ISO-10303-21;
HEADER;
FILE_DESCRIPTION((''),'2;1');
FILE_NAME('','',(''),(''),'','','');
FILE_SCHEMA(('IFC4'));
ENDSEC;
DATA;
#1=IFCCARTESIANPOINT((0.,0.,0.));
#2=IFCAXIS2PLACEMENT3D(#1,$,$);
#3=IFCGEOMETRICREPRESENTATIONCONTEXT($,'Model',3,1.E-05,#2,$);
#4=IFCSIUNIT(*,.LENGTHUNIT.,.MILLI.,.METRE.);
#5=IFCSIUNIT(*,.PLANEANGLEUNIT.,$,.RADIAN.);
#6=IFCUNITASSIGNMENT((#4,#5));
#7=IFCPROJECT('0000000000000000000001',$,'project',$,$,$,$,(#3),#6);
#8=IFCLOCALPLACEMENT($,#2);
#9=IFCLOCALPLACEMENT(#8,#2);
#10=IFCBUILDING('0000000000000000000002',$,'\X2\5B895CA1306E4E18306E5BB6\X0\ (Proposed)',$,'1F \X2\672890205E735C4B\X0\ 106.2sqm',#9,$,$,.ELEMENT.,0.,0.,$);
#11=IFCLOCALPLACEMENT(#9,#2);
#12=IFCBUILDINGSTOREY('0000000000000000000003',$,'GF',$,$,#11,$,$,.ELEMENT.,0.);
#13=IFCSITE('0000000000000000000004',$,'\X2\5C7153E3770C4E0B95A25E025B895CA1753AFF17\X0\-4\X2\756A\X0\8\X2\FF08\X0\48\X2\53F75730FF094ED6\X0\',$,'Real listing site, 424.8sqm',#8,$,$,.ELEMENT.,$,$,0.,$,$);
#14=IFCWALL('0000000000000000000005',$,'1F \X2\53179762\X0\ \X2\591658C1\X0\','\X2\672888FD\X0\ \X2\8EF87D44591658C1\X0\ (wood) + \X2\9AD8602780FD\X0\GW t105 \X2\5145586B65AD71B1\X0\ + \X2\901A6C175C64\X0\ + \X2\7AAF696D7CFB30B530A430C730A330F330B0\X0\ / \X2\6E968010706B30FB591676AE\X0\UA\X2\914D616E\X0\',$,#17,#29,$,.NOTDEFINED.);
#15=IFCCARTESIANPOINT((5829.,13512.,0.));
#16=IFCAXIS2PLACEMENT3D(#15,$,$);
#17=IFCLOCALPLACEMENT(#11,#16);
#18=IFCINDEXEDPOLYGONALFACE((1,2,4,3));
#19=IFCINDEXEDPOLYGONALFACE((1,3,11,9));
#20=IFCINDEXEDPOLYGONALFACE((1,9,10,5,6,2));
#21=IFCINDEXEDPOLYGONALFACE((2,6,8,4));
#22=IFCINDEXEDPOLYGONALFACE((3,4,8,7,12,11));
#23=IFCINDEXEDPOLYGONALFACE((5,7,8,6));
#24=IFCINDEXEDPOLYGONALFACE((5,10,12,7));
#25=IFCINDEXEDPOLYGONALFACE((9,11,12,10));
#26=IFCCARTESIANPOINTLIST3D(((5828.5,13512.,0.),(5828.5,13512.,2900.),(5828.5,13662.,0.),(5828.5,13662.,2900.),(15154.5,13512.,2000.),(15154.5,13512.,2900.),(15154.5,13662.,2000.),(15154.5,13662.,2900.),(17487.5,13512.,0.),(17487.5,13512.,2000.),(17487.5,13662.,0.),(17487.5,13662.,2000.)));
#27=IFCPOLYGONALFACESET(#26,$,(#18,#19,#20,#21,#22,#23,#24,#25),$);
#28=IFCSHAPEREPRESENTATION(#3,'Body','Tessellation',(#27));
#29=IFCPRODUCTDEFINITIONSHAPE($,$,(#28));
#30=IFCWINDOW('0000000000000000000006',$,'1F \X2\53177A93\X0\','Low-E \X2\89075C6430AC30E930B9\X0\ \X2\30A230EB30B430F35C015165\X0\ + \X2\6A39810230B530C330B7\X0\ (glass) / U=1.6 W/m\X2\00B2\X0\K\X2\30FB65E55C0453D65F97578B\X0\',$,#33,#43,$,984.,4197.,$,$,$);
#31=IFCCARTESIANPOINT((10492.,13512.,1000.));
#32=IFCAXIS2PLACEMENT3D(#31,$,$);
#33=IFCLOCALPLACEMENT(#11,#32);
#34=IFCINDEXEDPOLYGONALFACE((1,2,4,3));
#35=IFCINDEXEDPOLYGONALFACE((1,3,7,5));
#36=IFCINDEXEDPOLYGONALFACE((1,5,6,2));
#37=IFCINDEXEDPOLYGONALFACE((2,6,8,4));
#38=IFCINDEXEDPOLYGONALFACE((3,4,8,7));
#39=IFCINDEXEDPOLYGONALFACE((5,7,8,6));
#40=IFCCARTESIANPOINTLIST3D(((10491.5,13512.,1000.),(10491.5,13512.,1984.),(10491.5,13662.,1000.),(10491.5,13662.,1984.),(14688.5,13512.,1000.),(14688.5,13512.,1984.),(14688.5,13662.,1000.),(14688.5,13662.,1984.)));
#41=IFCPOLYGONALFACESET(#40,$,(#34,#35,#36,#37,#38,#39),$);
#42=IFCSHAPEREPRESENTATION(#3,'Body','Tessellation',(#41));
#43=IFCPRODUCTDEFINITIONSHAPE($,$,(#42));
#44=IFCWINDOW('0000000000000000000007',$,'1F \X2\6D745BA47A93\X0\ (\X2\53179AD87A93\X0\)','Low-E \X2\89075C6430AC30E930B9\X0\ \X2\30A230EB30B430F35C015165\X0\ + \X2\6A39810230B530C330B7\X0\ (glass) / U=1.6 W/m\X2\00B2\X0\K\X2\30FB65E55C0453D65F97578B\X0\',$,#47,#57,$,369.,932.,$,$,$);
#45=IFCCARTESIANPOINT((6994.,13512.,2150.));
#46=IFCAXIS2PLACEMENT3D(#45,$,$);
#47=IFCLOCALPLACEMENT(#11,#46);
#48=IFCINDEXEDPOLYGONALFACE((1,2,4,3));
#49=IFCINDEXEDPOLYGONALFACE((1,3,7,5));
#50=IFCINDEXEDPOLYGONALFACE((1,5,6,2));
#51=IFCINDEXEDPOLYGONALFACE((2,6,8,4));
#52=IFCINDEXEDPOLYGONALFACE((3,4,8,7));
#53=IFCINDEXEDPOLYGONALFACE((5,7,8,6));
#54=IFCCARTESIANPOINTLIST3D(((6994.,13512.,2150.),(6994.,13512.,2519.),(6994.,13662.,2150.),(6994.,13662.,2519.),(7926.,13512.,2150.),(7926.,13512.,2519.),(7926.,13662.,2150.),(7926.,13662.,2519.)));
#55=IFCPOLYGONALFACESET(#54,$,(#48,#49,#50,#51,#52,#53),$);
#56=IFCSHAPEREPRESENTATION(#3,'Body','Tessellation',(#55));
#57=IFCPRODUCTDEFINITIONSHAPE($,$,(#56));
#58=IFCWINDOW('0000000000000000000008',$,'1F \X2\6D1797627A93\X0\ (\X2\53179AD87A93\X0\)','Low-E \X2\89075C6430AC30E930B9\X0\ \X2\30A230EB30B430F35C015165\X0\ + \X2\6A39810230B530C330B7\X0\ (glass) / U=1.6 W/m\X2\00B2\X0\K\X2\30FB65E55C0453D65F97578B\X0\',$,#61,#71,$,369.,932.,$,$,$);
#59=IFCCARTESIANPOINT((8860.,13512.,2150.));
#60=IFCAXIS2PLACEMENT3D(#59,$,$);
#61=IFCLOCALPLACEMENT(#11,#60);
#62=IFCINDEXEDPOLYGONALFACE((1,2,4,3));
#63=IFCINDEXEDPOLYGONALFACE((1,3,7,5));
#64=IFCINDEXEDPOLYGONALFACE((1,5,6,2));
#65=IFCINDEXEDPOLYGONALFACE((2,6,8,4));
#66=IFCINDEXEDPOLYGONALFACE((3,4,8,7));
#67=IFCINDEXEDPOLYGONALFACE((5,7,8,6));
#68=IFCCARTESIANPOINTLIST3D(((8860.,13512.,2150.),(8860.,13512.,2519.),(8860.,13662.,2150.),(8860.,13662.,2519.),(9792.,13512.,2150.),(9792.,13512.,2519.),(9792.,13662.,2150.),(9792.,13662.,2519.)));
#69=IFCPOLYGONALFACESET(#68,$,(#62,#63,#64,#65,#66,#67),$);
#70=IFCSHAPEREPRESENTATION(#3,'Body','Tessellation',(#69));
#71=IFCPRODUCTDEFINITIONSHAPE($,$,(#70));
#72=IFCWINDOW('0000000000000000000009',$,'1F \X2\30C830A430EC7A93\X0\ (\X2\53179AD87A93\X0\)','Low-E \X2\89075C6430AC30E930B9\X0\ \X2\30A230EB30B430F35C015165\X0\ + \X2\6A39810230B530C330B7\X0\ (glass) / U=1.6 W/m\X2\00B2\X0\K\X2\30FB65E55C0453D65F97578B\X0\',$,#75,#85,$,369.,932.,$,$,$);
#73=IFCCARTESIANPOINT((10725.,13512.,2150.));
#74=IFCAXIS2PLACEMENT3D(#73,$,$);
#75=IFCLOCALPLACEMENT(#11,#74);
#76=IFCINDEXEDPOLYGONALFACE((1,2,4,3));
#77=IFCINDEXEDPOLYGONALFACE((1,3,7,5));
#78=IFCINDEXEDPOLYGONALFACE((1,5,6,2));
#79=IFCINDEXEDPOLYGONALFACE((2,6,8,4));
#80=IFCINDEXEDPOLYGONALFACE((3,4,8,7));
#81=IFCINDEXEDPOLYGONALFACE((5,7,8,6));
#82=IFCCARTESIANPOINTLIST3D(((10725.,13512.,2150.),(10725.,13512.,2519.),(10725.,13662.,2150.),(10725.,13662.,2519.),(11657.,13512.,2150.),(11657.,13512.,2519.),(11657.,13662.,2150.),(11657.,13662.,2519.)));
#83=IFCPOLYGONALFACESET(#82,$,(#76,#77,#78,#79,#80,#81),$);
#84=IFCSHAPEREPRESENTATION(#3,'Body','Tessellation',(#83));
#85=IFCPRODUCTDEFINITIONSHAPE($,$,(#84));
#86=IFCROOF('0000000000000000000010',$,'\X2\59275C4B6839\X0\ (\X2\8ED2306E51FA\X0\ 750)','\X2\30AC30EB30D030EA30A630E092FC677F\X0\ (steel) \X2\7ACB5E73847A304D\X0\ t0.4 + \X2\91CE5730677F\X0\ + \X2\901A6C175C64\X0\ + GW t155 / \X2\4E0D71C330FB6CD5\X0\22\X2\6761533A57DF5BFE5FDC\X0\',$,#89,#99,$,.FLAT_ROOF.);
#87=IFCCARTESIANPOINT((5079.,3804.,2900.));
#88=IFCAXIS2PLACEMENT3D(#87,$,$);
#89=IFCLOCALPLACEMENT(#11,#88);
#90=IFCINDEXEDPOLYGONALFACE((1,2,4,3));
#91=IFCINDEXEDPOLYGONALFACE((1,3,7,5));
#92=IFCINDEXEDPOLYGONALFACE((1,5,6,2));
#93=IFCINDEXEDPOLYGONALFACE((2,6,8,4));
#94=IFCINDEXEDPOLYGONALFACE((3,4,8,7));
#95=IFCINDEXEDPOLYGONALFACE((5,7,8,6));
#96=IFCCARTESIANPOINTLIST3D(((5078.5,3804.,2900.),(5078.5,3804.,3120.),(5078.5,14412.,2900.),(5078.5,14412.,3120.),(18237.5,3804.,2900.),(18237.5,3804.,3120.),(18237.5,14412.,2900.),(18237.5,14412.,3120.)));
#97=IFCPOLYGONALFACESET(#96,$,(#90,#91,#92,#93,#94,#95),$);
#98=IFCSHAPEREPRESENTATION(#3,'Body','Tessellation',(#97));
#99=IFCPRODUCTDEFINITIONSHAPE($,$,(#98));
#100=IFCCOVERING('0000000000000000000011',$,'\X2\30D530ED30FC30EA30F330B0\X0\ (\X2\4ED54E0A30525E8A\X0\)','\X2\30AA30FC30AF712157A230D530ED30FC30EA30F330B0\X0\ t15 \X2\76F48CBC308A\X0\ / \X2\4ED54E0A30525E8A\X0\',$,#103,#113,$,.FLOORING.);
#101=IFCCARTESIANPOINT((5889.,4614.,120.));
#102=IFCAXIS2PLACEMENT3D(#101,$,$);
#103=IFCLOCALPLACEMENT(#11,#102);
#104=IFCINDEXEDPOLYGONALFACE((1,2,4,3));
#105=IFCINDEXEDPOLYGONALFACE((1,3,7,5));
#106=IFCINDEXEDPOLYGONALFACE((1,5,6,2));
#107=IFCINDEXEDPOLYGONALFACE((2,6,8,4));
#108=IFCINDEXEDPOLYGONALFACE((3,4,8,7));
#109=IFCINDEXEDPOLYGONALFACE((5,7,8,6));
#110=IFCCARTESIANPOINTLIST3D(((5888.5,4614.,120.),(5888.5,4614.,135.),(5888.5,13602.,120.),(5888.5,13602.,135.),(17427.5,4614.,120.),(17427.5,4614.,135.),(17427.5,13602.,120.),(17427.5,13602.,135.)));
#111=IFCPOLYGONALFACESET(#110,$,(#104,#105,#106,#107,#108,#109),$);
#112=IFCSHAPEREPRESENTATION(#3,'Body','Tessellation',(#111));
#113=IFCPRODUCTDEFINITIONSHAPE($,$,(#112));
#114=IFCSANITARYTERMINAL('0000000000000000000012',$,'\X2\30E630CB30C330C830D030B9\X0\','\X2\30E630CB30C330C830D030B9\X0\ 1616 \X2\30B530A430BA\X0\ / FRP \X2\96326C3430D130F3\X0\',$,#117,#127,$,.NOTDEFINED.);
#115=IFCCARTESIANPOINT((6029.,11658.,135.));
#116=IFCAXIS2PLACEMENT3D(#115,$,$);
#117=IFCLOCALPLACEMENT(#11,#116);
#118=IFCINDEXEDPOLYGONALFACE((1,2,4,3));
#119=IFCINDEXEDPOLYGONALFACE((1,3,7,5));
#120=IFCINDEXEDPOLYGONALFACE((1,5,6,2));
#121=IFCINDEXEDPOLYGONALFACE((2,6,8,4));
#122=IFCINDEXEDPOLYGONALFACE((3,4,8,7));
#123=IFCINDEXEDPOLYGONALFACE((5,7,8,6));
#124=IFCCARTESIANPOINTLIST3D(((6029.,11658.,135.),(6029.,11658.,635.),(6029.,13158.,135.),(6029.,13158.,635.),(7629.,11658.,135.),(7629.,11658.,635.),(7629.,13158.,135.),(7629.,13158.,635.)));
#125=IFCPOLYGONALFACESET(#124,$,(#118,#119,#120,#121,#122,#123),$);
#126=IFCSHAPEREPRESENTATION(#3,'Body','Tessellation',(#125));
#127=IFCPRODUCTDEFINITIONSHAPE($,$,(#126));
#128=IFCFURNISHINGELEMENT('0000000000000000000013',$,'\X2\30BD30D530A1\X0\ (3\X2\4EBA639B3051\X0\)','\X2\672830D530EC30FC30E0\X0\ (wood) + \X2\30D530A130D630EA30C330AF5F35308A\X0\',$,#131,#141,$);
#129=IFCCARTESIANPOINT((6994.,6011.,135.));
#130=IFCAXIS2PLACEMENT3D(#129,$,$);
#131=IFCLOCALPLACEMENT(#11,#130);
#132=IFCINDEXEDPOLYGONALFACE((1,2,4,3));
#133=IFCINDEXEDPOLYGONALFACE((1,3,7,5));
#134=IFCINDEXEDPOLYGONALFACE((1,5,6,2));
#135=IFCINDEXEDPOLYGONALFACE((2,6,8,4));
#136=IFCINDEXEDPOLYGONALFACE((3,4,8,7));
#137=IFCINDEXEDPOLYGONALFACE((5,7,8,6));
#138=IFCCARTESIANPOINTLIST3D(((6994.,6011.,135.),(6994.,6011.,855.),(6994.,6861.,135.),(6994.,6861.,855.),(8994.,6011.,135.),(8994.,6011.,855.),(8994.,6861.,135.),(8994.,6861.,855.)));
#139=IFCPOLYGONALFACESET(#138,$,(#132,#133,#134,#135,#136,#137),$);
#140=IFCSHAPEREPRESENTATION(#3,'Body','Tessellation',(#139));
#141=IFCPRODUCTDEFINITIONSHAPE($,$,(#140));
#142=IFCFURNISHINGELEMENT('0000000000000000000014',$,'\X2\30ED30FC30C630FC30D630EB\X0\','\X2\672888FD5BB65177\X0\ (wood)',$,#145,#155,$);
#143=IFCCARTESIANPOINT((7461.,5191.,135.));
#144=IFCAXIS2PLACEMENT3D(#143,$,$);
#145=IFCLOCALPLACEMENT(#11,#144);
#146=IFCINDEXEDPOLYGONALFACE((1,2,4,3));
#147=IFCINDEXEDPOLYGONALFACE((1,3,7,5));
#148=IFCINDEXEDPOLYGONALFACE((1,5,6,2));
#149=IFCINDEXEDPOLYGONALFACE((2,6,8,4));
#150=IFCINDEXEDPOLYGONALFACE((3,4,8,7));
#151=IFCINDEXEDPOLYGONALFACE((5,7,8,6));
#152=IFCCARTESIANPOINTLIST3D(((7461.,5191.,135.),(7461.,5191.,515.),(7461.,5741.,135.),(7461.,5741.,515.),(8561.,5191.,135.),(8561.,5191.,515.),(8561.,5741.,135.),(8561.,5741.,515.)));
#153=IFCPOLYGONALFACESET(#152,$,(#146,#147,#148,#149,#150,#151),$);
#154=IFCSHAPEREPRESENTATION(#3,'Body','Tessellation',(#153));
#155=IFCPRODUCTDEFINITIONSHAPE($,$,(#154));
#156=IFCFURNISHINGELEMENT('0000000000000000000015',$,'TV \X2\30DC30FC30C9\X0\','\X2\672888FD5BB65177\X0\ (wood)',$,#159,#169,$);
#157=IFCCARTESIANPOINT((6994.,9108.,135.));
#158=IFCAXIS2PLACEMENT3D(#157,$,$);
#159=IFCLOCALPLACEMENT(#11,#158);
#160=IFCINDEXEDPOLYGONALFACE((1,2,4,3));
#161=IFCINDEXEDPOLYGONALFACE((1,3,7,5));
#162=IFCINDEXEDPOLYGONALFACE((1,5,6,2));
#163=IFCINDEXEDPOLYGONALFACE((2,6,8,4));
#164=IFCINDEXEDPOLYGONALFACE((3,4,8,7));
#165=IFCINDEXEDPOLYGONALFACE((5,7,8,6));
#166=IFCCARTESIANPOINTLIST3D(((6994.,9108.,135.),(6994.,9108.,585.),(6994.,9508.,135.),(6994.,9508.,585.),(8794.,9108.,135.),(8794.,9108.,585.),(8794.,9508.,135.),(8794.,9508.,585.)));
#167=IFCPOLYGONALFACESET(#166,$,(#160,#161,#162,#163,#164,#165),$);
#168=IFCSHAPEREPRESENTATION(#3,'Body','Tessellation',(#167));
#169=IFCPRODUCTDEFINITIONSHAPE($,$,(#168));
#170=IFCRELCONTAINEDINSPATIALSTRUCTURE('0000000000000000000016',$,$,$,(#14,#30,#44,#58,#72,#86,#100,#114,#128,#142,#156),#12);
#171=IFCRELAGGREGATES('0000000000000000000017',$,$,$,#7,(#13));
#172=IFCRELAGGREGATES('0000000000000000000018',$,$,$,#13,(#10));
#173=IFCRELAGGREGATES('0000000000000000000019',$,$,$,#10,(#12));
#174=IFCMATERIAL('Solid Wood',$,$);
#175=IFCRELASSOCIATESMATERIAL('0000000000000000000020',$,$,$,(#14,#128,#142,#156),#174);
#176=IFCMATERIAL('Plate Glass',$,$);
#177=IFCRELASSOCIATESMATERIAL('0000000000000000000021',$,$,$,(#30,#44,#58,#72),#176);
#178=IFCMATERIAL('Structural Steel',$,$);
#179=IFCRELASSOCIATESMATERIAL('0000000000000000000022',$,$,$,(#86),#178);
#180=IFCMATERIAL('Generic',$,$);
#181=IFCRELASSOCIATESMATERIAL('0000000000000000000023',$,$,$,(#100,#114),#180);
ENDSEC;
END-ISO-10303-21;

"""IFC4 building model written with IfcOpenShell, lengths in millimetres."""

from ifc_helpers import new_model, si_unit, frame, frame_2d, origin, place, context, project, spatial, rectangle, extrude, material, element, fill, save


model = new_model("IFC4")

# Units and contexts
model_context = context("Model", 3, precision=1e-05, world=origin())
ifc_project = project(units=[si_unit("LENGTHUNIT", "METRE", prefix="MILLI"), si_unit("PLANEANGLEUNIT", "RADIAN")], contexts=[model_context])

# Site, building, storey
site_placement = place(None, origin())
site = spatial("IfcSite", under=ifc_project, at=site_placement, Name="山口県下関市安岡町７-4番8（48号地）他", ObjectType="Real listing site, 424.8sqm", CompositionType="ELEMENT", RefElevation=0.0)
building_placement = place(site_placement, origin())
building = spatial("IfcBuilding", under=site, at=building_placement, Name="安岡の丘の家 (Proposed)", ObjectType="1F 木造平屋 106.2sqm", CompositionType="ELEMENT", ElevationOfRefHeight=0.0, ElevationOfTerrain=0.0)
storey_placement = place(building_placement, origin())
storey = spatial("IfcBuildingStorey", under=building, at=storey_placement, Name="GF", CompositionType="ELEMENT", Elevation=0.0)

# Shared definitions
ifc_material_1 = material(Name="Solid Wood")

# Shared definitions
ifc_material_2 = material(Name="Plate Glass")

# Wall, openings, windows
wall_1_placement = place(storey_placement, frame((5829.0, 13512.0, 0.0)))
wall_1 = element("IfcWall", 1, at=wall_1_placement, inside=storey, material=ifc_material_1, Name="1F 北面 外壁", Description="木製 軸組外壁 (wood) + 高性能GW t105 充填断熱 + 通気層 + 窯業系サイディング / 準耐火・外皮UA配慮", PredefinedType="NOTDEFINED", context=model_context, shape_type="SweptSolid", body=[
    extrude(rectangle(XDim=11659.0, YDim=150.0, at=frame_2d((5829.0, 75.0))), frame((5829.0, 13512.0, 0.0)), (0.0, 0.0, 1.0), 2900.0),
])
opening_1_placement = place(storey_placement, frame((10492.0, 13512.0, 1000.0)))
opening_1 = element("IfcOpeningElement", 2, at=opening_1_placement, cuts=wall_1, PredefinedType="NOTDEFINED", context=model_context, shape_type="SweptSolid", body=[
    extrude(rectangle(XDim=4197.0, YDim=150.0, at=frame_2d((2098.0, 75.0))), frame((10492.0, 13512.0, 1000.0)), (0.0, 0.0, 1.0), 984.0),
])
opening_2_placement = place(storey_placement, frame((6994.0, 13512.0, 2150.0)))
opening_2 = element("IfcOpeningElement", 3, at=opening_2_placement, cuts=wall_1, PredefinedType="NOTDEFINED", context=model_context, shape_type="SweptSolid", body=[
    extrude(rectangle(XDim=932.0, YDim=150.0, at=frame_2d((466.0, 75.0))), frame((6994.0, 13512.0, 2150.0)), (0.0, 0.0, 1.0), 369.0),
])
opening_3_placement = place(storey_placement, frame((8860.0, 13512.0, 2150.0)))
opening_3 = element("IfcOpeningElement", 4, at=opening_3_placement, cuts=wall_1, PredefinedType="NOTDEFINED", context=model_context, shape_type="SweptSolid", body=[
    extrude(rectangle(XDim=932.0, YDim=150.0, at=frame_2d((466.0, 75.0))), frame((8860.0, 13512.0, 2150.0)), (0.0, 0.0, 1.0), 369.0),
])
opening_4_placement = place(storey_placement, frame((10725.0, 13512.0, 2150.0)))
opening_4 = element("IfcOpeningElement", 5, at=opening_4_placement, cuts=wall_1, PredefinedType="NOTDEFINED", context=model_context, shape_type="SweptSolid", body=[
    extrude(rectangle(XDim=932.0, YDim=150.0, at=frame_2d((466.0, 75.0))), frame((10725.0, 13512.0, 2150.0)), (0.0, 0.0, 1.0), 369.0),
])
window_1_placement = place(storey_placement, frame((10492.0, 13512.0, 1000.0)))
window_1 = element("IfcWindow", 6, at=window_1_placement, inside=storey, material=ifc_material_2, Name="1F 北窓", Description="Low-E 複層ガラス アルゴン封入 + 樹脂サッシ (glass) / U=1.6 W/m²K・日射取得型", OverallHeight=984.0, OverallWidth=4197.0, context=model_context, shape_type="SweptSolid", body=[
    extrude(rectangle(XDim=4197.0, YDim=150.0, at=frame_2d((2098.0, 75.0))), frame((10492.0, 13512.0, 1000.0)), (0.0, 0.0, 1.0), 984.0),
])
fill(opening_1, window_1)
window_2_placement = place(storey_placement, frame((6994.0, 13512.0, 2150.0)))
window_2 = element("IfcWindow", 7, at=window_2_placement, inside=storey, material=ifc_material_2, Name="1F 浴室窓 (北高窓)", Description="Low-E 複層ガラス アルゴン封入 + 樹脂サッシ (glass) / U=1.6 W/m²K・日射取得型", OverallHeight=369.0, OverallWidth=932.0, context=model_context, shape_type="SweptSolid", body=[
    extrude(rectangle(XDim=932.0, YDim=150.0, at=frame_2d((466.0, 75.0))), frame((6994.0, 13512.0, 2150.0)), (0.0, 0.0, 1.0), 369.0),
])
fill(opening_2, window_2)
window_3_placement = place(storey_placement, frame((8860.0, 13512.0, 2150.0)))
window_3 = element("IfcWindow", 8, at=window_3_placement, inside=storey, material=ifc_material_2, Name="1F 洗面窓 (北高窓)", Description="Low-E 複層ガラス アルゴン封入 + 樹脂サッシ (glass) / U=1.6 W/m²K・日射取得型", OverallHeight=369.0, OverallWidth=932.0, context=model_context, shape_type="SweptSolid", body=[
    extrude(rectangle(XDim=932.0, YDim=150.0, at=frame_2d((466.0, 75.0))), frame((8860.0, 13512.0, 2150.0)), (0.0, 0.0, 1.0), 369.0),
])
fill(opening_3, window_3)
window_4_placement = place(storey_placement, frame((10725.0, 13512.0, 2150.0)))
window_4 = element("IfcWindow", 9, at=window_4_placement, inside=storey, material=ifc_material_2, Name="1F トイレ窓 (北高窓)", Description="Low-E 複層ガラス アルゴン封入 + 樹脂サッシ (glass) / U=1.6 W/m²K・日射取得型", OverallHeight=369.0, OverallWidth=932.0, context=model_context, shape_type="SweptSolid", body=[
    extrude(rectangle(XDim=932.0, YDim=150.0, at=frame_2d((466.0, 75.0))), frame((10725.0, 13512.0, 2150.0)), (0.0, 0.0, 1.0), 369.0),
])
fill(opening_4, window_4)

# Roof
ifc_material_3 = material(Name="Structural Steel")
roof_placement = place(storey_placement, frame((5079.0, 3804.0, 2900.0)))
element("IfcRoof", 10, at=roof_placement, inside=storey, material=ifc_material_3, Name="大屋根 (軒の出 750)", Description="ガルバリウム鋼板 (steel) 立平葺き t0.4 + 野地板 + 通気層 + GW t155 / 不燃・法22条区域対応", PredefinedType="FLAT_ROOF", context=model_context, shape_type="SweptSolid", body=[
    extrude(rectangle(XDim=13159.0, YDim=10608.0, at=frame_2d((6579.0, 5304.0))), frame((5079.0, 3804.0, 2900.0)), (0.0, 0.0, 1.0), 220.0),
])

# Covering
ifc_material_4 = material(Name="Generic")
covering_placement = place(storey_placement, frame((5889.0, 4614.0, 120.0)))
element("IfcCovering", 11, at=covering_placement, inside=storey, material=ifc_material_4, Name="フローリング (仕上げ床)", Description="オーク無垢フローリング t15 直貼り / 仕上げ床", PredefinedType="FLOORING", context=model_context, shape_type="SweptSolid", body=[
    extrude(rectangle(XDim=11539.0, YDim=8988.0, at=frame_2d((5769.0, 4494.0))), frame((5889.0, 4614.0, 120.0)), (0.0, 0.0, 1.0), 15.0),
])

# Sanitary terminal
sanitary_terminal_placement = place(storey_placement, frame((6029.0, 11658.0, 135.0)))
element("IfcSanitaryTerminal", 12, at=sanitary_terminal_placement, inside=storey, material=ifc_material_4, Name="ユニットバス", Description="ユニットバス 1616 サイズ / FRP 防水パン", PredefinedType="NOTDEFINED", context=model_context, shape_type="SweptSolid", body=[
    extrude(rectangle(XDim=1600.0, YDim=1500.0, at=frame_2d((800.0, 750.0))), frame((6029.0, 11658.0, 135.0)), (0.0, 0.0, 1.0), 500.0),
])

# Furnishing elements
furnishing_1_placement = place(storey_placement, frame((6994.0, 6011.0, 135.0)))
element("IfcFurnishingElement", 13, at=furnishing_1_placement, inside=storey, material=ifc_material_1, Name="ソファ (3人掛け)", Description="木フレーム (wood) + ファブリック張り", context=model_context, shape_type="SweptSolid", body=[
    extrude(rectangle(XDim=2000.0, YDim=850.0, at=frame_2d((1000.0, 425.0))), frame((6994.0, 6011.0, 135.0)), (0.0, 0.0, 1.0), 720.0),
])
furnishing_2_placement = place(storey_placement, frame((7461.0, 5191.0, 135.0)))
element("IfcFurnishingElement", 14, at=furnishing_2_placement, inside=storey, material=ifc_material_1, Name="ローテーブル", Description="木製家具 (wood)", context=model_context, shape_type="SweptSolid", body=[
    extrude(rectangle(XDim=1100.0, YDim=550.0, at=frame_2d((550.0, 275.0))), frame((7461.0, 5191.0, 135.0)), (0.0, 0.0, 1.0), 380.0),
])
furnishing_3_placement = place(storey_placement, frame((6994.0, 9108.0, 135.0)))
element("IfcFurnishingElement", 15, at=furnishing_3_placement, inside=storey, material=ifc_material_1, Name="TV ボード", Description="木製家具 (wood)", context=model_context, shape_type="SweptSolid", body=[
    extrude(rectangle(XDim=1800.0, YDim=400.0, at=frame_2d((900.0, 200.0))), frame((6994.0, 9108.0, 135.0)), (0.0, 0.0, 1.0), 450.0),
])

save(model, "model.ifc")
